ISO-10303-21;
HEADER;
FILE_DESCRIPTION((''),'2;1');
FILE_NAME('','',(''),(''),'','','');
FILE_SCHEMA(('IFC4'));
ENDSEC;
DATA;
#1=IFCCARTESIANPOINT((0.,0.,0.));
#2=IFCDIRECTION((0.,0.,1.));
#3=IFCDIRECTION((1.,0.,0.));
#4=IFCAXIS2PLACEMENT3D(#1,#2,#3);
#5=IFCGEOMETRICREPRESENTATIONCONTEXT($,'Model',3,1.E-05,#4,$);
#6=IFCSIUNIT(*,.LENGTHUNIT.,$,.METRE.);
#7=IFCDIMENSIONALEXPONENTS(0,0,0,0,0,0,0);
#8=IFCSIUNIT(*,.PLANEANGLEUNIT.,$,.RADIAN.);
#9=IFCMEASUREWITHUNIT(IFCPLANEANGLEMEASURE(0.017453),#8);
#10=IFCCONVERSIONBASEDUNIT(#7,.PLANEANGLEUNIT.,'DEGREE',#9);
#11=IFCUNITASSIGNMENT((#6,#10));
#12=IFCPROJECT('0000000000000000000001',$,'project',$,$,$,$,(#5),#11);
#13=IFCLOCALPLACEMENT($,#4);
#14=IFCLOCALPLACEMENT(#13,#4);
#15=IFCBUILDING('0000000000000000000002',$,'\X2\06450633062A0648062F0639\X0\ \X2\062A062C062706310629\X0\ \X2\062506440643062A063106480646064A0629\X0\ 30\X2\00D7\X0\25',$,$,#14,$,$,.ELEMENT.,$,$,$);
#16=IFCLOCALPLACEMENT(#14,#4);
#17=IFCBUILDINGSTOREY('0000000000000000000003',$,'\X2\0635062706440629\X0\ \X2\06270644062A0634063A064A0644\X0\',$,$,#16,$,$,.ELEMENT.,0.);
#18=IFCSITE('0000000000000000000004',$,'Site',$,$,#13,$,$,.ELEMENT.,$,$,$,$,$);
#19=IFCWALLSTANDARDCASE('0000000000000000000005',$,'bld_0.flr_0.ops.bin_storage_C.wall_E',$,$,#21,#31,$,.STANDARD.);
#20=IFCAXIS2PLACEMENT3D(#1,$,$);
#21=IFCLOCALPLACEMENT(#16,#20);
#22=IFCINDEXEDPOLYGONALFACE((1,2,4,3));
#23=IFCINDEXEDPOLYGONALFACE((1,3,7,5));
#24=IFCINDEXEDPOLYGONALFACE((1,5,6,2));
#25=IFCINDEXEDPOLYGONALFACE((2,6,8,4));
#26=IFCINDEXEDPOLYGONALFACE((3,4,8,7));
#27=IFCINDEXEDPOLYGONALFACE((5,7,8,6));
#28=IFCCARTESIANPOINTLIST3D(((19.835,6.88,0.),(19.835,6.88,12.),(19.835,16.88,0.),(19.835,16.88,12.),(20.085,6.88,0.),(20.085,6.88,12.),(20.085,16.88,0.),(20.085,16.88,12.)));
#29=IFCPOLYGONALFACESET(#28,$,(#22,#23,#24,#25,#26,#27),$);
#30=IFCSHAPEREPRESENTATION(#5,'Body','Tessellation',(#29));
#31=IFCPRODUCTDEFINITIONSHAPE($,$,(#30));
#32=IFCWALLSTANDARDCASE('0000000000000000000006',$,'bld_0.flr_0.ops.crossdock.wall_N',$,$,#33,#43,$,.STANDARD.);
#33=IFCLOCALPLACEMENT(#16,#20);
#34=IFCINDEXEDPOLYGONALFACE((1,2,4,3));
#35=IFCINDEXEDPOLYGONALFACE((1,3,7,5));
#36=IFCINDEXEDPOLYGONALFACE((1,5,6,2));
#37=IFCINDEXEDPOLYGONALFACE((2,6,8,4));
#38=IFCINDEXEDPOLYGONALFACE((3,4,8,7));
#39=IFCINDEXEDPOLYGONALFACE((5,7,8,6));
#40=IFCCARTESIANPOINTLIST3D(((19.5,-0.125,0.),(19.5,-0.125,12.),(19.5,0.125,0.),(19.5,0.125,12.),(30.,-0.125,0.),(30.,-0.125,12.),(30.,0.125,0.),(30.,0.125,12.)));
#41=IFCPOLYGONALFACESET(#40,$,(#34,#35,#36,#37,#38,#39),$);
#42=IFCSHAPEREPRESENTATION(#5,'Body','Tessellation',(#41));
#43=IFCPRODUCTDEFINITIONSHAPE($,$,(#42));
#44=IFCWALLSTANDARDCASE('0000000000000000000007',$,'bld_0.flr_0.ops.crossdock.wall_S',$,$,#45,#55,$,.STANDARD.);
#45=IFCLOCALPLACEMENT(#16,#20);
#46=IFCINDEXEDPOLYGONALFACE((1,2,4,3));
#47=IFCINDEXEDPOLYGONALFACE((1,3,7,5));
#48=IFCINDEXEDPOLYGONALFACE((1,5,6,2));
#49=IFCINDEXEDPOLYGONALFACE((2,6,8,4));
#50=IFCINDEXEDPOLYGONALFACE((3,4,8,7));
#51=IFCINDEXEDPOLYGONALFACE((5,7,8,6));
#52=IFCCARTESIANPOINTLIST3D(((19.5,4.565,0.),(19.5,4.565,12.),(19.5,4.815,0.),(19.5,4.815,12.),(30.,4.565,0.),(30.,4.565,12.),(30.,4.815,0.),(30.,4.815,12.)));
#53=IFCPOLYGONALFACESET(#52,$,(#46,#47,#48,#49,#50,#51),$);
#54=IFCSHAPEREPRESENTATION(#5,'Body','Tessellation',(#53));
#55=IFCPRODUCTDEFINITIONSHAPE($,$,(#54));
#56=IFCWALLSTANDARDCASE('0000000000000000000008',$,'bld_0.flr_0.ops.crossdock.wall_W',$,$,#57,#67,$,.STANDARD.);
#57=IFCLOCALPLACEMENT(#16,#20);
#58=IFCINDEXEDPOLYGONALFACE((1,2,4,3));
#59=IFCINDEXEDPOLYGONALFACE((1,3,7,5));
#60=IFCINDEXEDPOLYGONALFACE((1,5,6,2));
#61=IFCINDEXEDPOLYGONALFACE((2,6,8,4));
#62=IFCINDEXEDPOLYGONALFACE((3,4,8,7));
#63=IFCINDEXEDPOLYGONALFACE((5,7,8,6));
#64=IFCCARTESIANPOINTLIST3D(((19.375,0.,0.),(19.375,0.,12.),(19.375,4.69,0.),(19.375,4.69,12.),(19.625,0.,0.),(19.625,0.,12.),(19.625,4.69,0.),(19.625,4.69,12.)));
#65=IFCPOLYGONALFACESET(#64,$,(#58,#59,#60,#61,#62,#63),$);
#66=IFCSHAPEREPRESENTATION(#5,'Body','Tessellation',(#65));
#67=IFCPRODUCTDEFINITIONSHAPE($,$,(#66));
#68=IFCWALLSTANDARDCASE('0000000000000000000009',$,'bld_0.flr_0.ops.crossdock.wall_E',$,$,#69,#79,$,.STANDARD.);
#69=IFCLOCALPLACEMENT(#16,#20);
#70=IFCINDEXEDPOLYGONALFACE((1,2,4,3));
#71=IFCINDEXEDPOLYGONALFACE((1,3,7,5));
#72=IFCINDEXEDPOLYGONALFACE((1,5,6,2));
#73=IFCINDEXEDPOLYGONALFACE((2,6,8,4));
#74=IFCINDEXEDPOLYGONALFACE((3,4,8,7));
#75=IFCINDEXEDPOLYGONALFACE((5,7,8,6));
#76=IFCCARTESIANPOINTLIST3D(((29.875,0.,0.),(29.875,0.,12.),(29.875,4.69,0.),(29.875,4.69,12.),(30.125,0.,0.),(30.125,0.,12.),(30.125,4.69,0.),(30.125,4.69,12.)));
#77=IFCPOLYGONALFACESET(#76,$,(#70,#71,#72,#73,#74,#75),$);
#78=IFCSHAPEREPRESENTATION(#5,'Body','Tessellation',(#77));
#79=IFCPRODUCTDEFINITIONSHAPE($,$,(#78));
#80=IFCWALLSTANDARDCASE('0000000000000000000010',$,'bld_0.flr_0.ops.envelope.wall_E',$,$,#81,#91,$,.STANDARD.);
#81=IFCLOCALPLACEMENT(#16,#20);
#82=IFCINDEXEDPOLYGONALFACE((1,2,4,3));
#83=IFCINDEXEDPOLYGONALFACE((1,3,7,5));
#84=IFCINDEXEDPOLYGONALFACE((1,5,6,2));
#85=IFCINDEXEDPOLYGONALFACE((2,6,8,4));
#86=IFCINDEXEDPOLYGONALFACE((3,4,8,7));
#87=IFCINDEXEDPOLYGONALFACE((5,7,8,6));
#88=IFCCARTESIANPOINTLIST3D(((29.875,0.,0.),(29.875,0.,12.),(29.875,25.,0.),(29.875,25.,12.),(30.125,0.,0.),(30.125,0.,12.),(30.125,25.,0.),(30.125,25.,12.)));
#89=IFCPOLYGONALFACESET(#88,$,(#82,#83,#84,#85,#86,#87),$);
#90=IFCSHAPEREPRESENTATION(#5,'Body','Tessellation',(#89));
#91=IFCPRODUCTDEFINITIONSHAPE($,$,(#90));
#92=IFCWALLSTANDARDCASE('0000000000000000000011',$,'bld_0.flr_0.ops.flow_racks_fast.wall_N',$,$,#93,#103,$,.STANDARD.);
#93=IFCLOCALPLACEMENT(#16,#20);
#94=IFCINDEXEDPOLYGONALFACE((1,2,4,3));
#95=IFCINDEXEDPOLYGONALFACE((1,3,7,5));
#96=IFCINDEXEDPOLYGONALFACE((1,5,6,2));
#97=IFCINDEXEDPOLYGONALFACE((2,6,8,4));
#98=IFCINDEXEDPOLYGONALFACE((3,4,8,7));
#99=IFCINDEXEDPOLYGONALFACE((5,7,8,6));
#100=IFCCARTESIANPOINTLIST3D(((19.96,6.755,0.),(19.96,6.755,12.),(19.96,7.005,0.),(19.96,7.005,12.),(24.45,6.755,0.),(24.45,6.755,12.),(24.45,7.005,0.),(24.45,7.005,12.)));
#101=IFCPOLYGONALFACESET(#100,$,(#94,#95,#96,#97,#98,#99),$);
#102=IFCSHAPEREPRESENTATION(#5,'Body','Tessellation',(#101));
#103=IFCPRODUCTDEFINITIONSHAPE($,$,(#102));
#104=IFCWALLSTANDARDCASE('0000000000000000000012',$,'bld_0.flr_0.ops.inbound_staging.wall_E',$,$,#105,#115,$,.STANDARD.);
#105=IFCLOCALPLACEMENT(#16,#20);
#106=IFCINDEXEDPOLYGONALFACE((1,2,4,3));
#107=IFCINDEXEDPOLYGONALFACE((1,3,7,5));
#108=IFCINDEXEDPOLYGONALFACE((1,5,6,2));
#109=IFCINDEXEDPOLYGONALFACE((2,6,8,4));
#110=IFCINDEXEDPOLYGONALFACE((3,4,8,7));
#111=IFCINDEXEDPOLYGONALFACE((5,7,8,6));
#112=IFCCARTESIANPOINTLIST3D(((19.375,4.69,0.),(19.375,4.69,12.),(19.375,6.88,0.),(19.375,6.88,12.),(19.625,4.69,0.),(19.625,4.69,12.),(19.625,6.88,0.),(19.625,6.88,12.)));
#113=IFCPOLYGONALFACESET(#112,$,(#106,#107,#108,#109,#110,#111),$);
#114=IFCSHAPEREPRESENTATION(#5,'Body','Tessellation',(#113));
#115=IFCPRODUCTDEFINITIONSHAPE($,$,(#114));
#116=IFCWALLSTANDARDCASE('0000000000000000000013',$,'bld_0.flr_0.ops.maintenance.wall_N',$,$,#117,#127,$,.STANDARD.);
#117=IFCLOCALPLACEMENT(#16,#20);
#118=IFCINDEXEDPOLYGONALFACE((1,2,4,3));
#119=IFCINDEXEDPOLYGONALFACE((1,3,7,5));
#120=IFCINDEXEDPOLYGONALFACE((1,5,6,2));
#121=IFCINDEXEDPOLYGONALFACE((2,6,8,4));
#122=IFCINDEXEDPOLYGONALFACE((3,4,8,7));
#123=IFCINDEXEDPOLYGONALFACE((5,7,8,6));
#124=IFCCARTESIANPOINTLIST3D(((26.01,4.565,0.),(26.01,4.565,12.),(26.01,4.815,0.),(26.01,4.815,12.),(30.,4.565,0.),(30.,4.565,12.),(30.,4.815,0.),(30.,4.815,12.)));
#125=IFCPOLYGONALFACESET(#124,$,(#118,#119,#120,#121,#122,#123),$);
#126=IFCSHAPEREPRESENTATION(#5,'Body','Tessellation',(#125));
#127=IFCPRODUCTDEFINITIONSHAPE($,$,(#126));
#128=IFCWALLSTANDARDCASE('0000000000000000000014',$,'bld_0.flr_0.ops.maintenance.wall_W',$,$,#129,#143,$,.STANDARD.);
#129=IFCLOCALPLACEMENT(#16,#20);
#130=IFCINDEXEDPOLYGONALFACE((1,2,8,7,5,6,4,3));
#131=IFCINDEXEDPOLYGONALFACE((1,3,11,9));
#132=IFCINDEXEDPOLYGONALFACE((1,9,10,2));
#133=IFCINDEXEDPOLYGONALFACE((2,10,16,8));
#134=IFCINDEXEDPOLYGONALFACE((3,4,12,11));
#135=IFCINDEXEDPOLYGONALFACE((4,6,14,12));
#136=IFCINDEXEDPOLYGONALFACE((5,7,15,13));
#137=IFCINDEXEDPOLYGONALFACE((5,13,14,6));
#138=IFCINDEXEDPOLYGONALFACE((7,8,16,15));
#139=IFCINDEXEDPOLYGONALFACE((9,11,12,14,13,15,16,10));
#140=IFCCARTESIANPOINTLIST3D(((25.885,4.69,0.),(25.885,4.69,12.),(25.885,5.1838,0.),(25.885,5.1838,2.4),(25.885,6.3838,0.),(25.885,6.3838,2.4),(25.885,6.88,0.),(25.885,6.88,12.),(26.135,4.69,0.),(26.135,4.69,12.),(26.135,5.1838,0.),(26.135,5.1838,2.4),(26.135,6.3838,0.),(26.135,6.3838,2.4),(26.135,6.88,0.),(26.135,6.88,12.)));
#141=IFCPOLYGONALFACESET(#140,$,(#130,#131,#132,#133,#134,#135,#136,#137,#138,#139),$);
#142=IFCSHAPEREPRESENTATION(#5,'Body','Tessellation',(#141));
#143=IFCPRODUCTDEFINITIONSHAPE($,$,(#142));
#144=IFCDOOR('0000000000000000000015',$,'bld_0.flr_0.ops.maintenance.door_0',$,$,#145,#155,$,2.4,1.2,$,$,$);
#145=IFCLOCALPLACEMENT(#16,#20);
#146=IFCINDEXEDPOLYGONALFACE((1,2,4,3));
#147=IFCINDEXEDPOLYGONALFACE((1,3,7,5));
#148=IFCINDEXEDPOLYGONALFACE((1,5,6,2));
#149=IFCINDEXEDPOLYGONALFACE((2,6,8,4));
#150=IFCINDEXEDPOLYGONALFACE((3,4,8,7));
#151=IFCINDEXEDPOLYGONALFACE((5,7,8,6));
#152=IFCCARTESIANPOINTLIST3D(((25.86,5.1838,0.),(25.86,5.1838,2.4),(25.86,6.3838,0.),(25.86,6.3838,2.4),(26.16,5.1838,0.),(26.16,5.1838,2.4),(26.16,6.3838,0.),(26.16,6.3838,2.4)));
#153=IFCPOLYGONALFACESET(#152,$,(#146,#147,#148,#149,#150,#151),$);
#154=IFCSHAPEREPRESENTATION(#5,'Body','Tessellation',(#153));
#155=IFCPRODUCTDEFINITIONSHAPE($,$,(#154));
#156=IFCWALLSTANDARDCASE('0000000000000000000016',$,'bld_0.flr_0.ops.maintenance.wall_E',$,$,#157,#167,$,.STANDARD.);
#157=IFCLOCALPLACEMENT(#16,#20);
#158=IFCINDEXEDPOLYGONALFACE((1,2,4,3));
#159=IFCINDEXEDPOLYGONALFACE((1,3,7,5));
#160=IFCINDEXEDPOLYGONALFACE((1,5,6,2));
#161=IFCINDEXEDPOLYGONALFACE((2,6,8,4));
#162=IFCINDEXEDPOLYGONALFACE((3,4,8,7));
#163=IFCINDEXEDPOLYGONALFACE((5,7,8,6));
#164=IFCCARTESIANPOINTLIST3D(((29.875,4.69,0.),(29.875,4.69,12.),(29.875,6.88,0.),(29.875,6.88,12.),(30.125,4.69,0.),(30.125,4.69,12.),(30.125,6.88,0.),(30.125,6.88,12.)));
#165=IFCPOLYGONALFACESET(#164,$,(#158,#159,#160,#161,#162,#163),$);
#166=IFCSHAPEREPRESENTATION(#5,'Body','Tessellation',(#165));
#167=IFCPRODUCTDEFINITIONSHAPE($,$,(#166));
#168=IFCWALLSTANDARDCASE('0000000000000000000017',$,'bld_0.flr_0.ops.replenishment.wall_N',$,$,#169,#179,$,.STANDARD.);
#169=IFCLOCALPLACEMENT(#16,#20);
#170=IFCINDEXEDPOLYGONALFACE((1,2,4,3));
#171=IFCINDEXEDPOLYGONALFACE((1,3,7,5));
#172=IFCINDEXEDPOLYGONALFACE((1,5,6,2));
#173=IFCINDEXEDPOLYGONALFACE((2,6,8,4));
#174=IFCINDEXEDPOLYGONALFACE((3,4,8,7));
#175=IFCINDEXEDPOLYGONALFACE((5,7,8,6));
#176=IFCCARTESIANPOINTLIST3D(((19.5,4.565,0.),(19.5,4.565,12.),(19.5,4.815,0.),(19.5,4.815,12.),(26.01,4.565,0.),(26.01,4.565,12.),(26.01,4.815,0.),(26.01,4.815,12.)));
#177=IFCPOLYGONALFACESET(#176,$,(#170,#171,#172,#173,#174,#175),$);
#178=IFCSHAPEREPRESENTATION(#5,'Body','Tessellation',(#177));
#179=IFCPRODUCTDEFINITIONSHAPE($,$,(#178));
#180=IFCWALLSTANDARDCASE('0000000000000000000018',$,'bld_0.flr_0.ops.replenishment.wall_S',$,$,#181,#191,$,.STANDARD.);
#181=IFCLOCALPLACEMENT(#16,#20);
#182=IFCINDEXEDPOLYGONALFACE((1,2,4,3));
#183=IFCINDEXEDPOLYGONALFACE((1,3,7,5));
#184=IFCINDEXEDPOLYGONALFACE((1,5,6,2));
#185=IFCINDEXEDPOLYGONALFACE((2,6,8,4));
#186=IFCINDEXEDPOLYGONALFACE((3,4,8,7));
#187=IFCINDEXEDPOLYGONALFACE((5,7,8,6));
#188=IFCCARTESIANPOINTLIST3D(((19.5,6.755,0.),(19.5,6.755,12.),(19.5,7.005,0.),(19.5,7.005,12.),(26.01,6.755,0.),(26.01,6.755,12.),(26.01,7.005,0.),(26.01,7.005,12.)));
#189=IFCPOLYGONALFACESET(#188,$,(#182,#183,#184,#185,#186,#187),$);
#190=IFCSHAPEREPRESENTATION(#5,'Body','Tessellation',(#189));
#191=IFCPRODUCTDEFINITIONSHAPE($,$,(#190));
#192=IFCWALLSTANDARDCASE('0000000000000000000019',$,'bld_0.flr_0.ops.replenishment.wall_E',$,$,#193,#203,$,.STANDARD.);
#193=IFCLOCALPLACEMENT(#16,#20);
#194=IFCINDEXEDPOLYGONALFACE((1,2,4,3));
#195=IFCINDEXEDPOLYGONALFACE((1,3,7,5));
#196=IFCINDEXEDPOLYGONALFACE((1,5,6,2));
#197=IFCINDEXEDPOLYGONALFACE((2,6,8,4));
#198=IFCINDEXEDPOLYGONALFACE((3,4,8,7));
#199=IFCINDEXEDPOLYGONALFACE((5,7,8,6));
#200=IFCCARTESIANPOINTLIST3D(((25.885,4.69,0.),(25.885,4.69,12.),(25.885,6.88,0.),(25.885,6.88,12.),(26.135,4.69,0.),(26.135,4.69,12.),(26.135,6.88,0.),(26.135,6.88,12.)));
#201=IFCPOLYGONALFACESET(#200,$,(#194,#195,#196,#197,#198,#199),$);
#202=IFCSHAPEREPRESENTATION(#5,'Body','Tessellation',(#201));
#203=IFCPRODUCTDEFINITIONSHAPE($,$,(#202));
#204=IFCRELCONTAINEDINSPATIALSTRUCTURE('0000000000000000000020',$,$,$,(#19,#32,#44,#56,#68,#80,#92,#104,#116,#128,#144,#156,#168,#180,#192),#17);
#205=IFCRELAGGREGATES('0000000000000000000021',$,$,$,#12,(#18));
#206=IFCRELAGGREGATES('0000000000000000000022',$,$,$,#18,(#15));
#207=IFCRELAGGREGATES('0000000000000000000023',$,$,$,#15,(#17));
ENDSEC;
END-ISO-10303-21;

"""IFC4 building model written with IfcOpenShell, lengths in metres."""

from ifc_helpers import new_model, entity, si_unit, converted_unit, frame, frame_2d, origin_with_axes, origin_2d_with_axis, place, context, project, spatial, rectangle, extrude, element, fill, save


model = new_model("IFC4")

# Units and contexts
model_context = context("Model", 3, precision=1e-05, world=origin_with_axes())
ifc_project = project(units=[si_unit("LENGTHUNIT", "METRE"), converted_unit("PLANEANGLEUNIT", "DEGREE", entity("IfcPlaneAngleMeasure", 0.017453), si_unit("PLANEANGLEUNIT", "RADIAN"), dimensions=[0, 0, 0, 0, 0, 0, 0])], contexts=[model_context])

# Site, building, storey
site_placement = place(None, origin_with_axes())
site = spatial("IfcSite", under=ifc_project, at=site_placement, Name="Site", CompositionType="ELEMENT")
building_placement = place(site_placement, origin_with_axes())
building = spatial("IfcBuilding", under=site, at=building_placement, Name="مستودع تجارة إلكترونية 30×25", CompositionType="ELEMENT")
storey_placement = place(building_placement, origin_with_axes())
storey = spatial("IfcBuildingStorey", under=building, at=storey_placement, Name="صالة التشغيل", CompositionType="ELEMENT", Elevation=0.0)

# Walls
wall_1_placement = place(storey_placement, frame((19.96, 6.88, 0.0), z_axis=(0.0, 0.0, 1.0), x_axis=(0.0, 1.0, 0.0)))
element("IfcWallStandardCase", 1, at=wall_1_placement, inside=storey, Name="bld_0.flr_0.ops.bin_storage_C.wall_E", PredefinedType="STANDARD", context=model_context, shape_type="SweptSolid", body=[
    extrude(rectangle(XDim=10.0, YDim=0.25, at=frame_2d((5.0, 0.0), x_axis=(1.0, 0.0))), origin_with_axes(), (0.0, 0.0, 1.0), 12.0),
])
for number, where, z_axis, x_axis, name in (
    (2, (19.5, 0.0, 0.0), (0.0, 0.0, 1.0), (1.0, 0.0, 0.0), "bld_0.flr_0.ops.crossdock.wall_N"),
    (3, (19.5, 4.69, 0.0), (0.0, 0.0, 1.0), (1.0, 0.0, 0.0), "bld_0.flr_0.ops.crossdock.wall_S"),
):
    element("IfcWallStandardCase", number, at=place(storey_placement, frame(where, z_axis=z_axis, x_axis=x_axis)), inside=storey, Name=name, PredefinedType="STANDARD", context=model_context, shape_type="SweptSolid", body=[
        extrude(rectangle(XDim=10.5, YDim=0.25, at=frame_2d((5.25, 0.0), x_axis=(1.0, 0.0))), origin_with_axes(), (0.0, 0.0, 1.0), 12.0),
    ])
for number, where, z_axis, x_axis, name in (
    (4, (19.5, 0.0, 0.0), (0.0, 0.0, 1.0), (0.0, 1.0, 0.0), "bld_0.flr_0.ops.crossdock.wall_W"),
    (5, (30.0, 0.0, 0.0), (0.0, 0.0, 1.0), (0.0, 1.0, 0.0), "bld_0.flr_0.ops.crossdock.wall_E"),
):
    element("IfcWallStandardCase", number, at=place(storey_placement, frame(where, z_axis=z_axis, x_axis=x_axis)), inside=storey, Name=name, PredefinedType="STANDARD", context=model_context, shape_type="SweptSolid", body=[
        extrude(rectangle(XDim=4.69, YDim=0.25, at=frame_2d((2.345, 0.0), x_axis=(1.0, 0.0))), origin_with_axes(), (0.0, 0.0, 1.0), 12.0),
    ])
wall_2_placement = place(storey_placement, frame((30.0, 0.0, 0.0), z_axis=(0.0, 0.0, 1.0), x_axis=(0.0, 1.0, 0.0)))
element("IfcWallStandardCase", 6, at=wall_2_placement, inside=storey, Name="bld_0.flr_0.ops.envelope.wall_E", PredefinedType="STANDARD", context=model_context, shape_type="SweptSolid", body=[
    extrude(rectangle(XDim=25.0, YDim=0.25, at=frame_2d((12.5, 0.0), x_axis=(1.0, 0.0))), origin_with_axes(), (0.0, 0.0, 1.0), 12.0),
])
wall_3_placement = place(storey_placement, frame((19.96, 6.88, 0.0), z_axis=(0.0, 0.0, 1.0), x_axis=(1.0, 0.0, 0.0)))
element("IfcWallStandardCase", 7, at=wall_3_placement, inside=storey, Name="bld_0.flr_0.ops.flow_racks_fast.wall_N", PredefinedType="STANDARD", context=model_context, shape_type="SweptSolid", body=[
    extrude(rectangle(XDim=4.49, YDim=0.25, at=frame_2d((2.245, 0.0), x_axis=(1.0, 0.0))), origin_with_axes(), (0.0, 0.0, 1.0), 12.0),
])
wall_4_placement = place(storey_placement, frame((19.5, 4.69, 0.0), z_axis=(0.0, 0.0, 1.0), x_axis=(0.0, 1.0, 0.0)))
element("IfcWallStandardCase", 8, at=wall_4_placement, inside=storey, Name="bld_0.flr_0.ops.inbound_staging.wall_E", PredefinedType="STANDARD", context=model_context, shape_type="SweptSolid", body=[
    extrude(rectangle(XDim=2.19, YDim=0.25, at=frame_2d((1.095, 0.0), x_axis=(1.0, 0.0))), origin_with_axes(), (0.0, 0.0, 1.0), 12.0),
])
wall_5_placement = place(storey_placement, frame((26.01, 4.69, 0.0), z_axis=(0.0, 0.0, 1.0), x_axis=(1.0, 0.0, 0.0)))
element("IfcWallStandardCase", 9, at=wall_5_placement, inside=storey, Name="bld_0.flr_0.ops.maintenance.wall_N", PredefinedType="STANDARD", context=model_context, shape_type="SweptSolid", body=[
    extrude(rectangle(XDim=3.99, YDim=0.25, at=frame_2d((1.995, 0.0), x_axis=(1.0, 0.0))), origin_with_axes(), (0.0, 0.0, 1.0), 12.0),
])

# Wall, opening, door
wall_6_placement = place(storey_placement, frame((26.01, 4.69, 0.0), z_axis=(0.0, 0.0, 1.0), x_axis=(0.0, 1.0, 0.0)))
wall_6 = element("IfcWallStandardCase", 10, at=wall_6_placement, inside=storey, Name="bld_0.flr_0.ops.maintenance.wall_W", PredefinedType="STANDARD", context=model_context, shape_type="SweptSolid", body=[
    extrude(rectangle(XDim=2.19, YDim=0.25, at=frame_2d((1.095, 0.0), x_axis=(1.0, 0.0))), origin_with_axes(), (0.0, 0.0, 1.0), 12.0),
])
opening_placement = place(storey_placement, frame((26.01, 5.7838, 0.0), z_axis=(0.0, 0.0, 1.0), x_axis=(0.0, 1.0, 0.0)))
opening = element("IfcOpeningElement", 11, at=opening_placement, cuts=wall_6, PredefinedType="OPENING", context=model_context, shape_type="SweptSolid", body=[
    extrude(rectangle(XDim=1.2, YDim=0.3, at=origin_2d_with_axis()), origin_with_axes(), (0.0, 0.0, 1.0), 2.4),
])
door_placement = place(storey_placement, frame((26.01, 5.7838, 0.0), z_axis=(0.0, 0.0, 1.0), x_axis=(0.0, 1.0, 0.0)))
door = element("IfcDoor", 12, at=door_placement, inside=storey, Name="bld_0.flr_0.ops.maintenance.door_0", OverallHeight=2.4, OverallWidth=1.2, context=model_context, shape_type="SweptSolid", body=[
    extrude(rectangle(XDim=1.2, YDim=0.3, at=origin_2d_with_axis()), origin_with_axes(), (0.0, 0.0, 1.0), 2.4),
])
fill(opening, door)

# Walls
wall_7_placement = place(storey_placement, frame((30.0, 4.69, 0.0), z_axis=(0.0, 0.0, 1.0), x_axis=(0.0, 1.0, 0.0)))
element("IfcWallStandardCase", 13, at=wall_7_placement, inside=storey, Name="bld_0.flr_0.ops.maintenance.wall_E", PredefinedType="STANDARD", context=model_context, shape_type="SweptSolid", body=[
    extrude(rectangle(XDim=2.19, YDim=0.25, at=frame_2d((1.095, 0.0), x_axis=(1.0, 0.0))), origin_with_axes(), (0.0, 0.0, 1.0), 12.0),
])
for number, where, z_axis, x_axis, name in (
    (14, (19.5, 4.69, 0.0), (0.0, 0.0, 1.0), (1.0, 0.0, 0.0), "bld_0.flr_0.ops.replenishment.wall_N"),
    (15, (19.5, 6.88, 0.0), (0.0, 0.0, 1.0), (1.0, 0.0, 0.0), "bld_0.flr_0.ops.replenishment.wall_S"),
):
    element("IfcWallStandardCase", number, at=place(storey_placement, frame(where, z_axis=z_axis, x_axis=x_axis)), inside=storey, Name=name, PredefinedType="STANDARD", context=model_context, shape_type="SweptSolid", body=[
        extrude(rectangle(XDim=6.51, YDim=0.25, at=frame_2d((3.255, 0.0), x_axis=(1.0, 0.0))), origin_with_axes(), (0.0, 0.0, 1.0), 12.0),
    ])
for number, where, z_axis, x_axis, name in (
    (16, (26.01, 4.69, 0.0), (0.0, 0.0, 1.0), (0.0, 1.0, 0.0), "bld_0.flr_0.ops.replenishment.wall_E"),
):
    element("IfcWallStandardCase", number, at=place(storey_placement, frame(where, z_axis=z_axis, x_axis=x_axis)), inside=storey, Name=name, PredefinedType="STANDARD", context=model_context, shape_type="SweptSolid", body=[
        extrude(rectangle(XDim=2.19, YDim=0.25, at=frame_2d((1.095, 0.0), x_axis=(1.0, 0.0))), origin_with_axes(), (0.0, 0.0, 1.0), 12.0),
    ])

save(model, "model.ifc")
